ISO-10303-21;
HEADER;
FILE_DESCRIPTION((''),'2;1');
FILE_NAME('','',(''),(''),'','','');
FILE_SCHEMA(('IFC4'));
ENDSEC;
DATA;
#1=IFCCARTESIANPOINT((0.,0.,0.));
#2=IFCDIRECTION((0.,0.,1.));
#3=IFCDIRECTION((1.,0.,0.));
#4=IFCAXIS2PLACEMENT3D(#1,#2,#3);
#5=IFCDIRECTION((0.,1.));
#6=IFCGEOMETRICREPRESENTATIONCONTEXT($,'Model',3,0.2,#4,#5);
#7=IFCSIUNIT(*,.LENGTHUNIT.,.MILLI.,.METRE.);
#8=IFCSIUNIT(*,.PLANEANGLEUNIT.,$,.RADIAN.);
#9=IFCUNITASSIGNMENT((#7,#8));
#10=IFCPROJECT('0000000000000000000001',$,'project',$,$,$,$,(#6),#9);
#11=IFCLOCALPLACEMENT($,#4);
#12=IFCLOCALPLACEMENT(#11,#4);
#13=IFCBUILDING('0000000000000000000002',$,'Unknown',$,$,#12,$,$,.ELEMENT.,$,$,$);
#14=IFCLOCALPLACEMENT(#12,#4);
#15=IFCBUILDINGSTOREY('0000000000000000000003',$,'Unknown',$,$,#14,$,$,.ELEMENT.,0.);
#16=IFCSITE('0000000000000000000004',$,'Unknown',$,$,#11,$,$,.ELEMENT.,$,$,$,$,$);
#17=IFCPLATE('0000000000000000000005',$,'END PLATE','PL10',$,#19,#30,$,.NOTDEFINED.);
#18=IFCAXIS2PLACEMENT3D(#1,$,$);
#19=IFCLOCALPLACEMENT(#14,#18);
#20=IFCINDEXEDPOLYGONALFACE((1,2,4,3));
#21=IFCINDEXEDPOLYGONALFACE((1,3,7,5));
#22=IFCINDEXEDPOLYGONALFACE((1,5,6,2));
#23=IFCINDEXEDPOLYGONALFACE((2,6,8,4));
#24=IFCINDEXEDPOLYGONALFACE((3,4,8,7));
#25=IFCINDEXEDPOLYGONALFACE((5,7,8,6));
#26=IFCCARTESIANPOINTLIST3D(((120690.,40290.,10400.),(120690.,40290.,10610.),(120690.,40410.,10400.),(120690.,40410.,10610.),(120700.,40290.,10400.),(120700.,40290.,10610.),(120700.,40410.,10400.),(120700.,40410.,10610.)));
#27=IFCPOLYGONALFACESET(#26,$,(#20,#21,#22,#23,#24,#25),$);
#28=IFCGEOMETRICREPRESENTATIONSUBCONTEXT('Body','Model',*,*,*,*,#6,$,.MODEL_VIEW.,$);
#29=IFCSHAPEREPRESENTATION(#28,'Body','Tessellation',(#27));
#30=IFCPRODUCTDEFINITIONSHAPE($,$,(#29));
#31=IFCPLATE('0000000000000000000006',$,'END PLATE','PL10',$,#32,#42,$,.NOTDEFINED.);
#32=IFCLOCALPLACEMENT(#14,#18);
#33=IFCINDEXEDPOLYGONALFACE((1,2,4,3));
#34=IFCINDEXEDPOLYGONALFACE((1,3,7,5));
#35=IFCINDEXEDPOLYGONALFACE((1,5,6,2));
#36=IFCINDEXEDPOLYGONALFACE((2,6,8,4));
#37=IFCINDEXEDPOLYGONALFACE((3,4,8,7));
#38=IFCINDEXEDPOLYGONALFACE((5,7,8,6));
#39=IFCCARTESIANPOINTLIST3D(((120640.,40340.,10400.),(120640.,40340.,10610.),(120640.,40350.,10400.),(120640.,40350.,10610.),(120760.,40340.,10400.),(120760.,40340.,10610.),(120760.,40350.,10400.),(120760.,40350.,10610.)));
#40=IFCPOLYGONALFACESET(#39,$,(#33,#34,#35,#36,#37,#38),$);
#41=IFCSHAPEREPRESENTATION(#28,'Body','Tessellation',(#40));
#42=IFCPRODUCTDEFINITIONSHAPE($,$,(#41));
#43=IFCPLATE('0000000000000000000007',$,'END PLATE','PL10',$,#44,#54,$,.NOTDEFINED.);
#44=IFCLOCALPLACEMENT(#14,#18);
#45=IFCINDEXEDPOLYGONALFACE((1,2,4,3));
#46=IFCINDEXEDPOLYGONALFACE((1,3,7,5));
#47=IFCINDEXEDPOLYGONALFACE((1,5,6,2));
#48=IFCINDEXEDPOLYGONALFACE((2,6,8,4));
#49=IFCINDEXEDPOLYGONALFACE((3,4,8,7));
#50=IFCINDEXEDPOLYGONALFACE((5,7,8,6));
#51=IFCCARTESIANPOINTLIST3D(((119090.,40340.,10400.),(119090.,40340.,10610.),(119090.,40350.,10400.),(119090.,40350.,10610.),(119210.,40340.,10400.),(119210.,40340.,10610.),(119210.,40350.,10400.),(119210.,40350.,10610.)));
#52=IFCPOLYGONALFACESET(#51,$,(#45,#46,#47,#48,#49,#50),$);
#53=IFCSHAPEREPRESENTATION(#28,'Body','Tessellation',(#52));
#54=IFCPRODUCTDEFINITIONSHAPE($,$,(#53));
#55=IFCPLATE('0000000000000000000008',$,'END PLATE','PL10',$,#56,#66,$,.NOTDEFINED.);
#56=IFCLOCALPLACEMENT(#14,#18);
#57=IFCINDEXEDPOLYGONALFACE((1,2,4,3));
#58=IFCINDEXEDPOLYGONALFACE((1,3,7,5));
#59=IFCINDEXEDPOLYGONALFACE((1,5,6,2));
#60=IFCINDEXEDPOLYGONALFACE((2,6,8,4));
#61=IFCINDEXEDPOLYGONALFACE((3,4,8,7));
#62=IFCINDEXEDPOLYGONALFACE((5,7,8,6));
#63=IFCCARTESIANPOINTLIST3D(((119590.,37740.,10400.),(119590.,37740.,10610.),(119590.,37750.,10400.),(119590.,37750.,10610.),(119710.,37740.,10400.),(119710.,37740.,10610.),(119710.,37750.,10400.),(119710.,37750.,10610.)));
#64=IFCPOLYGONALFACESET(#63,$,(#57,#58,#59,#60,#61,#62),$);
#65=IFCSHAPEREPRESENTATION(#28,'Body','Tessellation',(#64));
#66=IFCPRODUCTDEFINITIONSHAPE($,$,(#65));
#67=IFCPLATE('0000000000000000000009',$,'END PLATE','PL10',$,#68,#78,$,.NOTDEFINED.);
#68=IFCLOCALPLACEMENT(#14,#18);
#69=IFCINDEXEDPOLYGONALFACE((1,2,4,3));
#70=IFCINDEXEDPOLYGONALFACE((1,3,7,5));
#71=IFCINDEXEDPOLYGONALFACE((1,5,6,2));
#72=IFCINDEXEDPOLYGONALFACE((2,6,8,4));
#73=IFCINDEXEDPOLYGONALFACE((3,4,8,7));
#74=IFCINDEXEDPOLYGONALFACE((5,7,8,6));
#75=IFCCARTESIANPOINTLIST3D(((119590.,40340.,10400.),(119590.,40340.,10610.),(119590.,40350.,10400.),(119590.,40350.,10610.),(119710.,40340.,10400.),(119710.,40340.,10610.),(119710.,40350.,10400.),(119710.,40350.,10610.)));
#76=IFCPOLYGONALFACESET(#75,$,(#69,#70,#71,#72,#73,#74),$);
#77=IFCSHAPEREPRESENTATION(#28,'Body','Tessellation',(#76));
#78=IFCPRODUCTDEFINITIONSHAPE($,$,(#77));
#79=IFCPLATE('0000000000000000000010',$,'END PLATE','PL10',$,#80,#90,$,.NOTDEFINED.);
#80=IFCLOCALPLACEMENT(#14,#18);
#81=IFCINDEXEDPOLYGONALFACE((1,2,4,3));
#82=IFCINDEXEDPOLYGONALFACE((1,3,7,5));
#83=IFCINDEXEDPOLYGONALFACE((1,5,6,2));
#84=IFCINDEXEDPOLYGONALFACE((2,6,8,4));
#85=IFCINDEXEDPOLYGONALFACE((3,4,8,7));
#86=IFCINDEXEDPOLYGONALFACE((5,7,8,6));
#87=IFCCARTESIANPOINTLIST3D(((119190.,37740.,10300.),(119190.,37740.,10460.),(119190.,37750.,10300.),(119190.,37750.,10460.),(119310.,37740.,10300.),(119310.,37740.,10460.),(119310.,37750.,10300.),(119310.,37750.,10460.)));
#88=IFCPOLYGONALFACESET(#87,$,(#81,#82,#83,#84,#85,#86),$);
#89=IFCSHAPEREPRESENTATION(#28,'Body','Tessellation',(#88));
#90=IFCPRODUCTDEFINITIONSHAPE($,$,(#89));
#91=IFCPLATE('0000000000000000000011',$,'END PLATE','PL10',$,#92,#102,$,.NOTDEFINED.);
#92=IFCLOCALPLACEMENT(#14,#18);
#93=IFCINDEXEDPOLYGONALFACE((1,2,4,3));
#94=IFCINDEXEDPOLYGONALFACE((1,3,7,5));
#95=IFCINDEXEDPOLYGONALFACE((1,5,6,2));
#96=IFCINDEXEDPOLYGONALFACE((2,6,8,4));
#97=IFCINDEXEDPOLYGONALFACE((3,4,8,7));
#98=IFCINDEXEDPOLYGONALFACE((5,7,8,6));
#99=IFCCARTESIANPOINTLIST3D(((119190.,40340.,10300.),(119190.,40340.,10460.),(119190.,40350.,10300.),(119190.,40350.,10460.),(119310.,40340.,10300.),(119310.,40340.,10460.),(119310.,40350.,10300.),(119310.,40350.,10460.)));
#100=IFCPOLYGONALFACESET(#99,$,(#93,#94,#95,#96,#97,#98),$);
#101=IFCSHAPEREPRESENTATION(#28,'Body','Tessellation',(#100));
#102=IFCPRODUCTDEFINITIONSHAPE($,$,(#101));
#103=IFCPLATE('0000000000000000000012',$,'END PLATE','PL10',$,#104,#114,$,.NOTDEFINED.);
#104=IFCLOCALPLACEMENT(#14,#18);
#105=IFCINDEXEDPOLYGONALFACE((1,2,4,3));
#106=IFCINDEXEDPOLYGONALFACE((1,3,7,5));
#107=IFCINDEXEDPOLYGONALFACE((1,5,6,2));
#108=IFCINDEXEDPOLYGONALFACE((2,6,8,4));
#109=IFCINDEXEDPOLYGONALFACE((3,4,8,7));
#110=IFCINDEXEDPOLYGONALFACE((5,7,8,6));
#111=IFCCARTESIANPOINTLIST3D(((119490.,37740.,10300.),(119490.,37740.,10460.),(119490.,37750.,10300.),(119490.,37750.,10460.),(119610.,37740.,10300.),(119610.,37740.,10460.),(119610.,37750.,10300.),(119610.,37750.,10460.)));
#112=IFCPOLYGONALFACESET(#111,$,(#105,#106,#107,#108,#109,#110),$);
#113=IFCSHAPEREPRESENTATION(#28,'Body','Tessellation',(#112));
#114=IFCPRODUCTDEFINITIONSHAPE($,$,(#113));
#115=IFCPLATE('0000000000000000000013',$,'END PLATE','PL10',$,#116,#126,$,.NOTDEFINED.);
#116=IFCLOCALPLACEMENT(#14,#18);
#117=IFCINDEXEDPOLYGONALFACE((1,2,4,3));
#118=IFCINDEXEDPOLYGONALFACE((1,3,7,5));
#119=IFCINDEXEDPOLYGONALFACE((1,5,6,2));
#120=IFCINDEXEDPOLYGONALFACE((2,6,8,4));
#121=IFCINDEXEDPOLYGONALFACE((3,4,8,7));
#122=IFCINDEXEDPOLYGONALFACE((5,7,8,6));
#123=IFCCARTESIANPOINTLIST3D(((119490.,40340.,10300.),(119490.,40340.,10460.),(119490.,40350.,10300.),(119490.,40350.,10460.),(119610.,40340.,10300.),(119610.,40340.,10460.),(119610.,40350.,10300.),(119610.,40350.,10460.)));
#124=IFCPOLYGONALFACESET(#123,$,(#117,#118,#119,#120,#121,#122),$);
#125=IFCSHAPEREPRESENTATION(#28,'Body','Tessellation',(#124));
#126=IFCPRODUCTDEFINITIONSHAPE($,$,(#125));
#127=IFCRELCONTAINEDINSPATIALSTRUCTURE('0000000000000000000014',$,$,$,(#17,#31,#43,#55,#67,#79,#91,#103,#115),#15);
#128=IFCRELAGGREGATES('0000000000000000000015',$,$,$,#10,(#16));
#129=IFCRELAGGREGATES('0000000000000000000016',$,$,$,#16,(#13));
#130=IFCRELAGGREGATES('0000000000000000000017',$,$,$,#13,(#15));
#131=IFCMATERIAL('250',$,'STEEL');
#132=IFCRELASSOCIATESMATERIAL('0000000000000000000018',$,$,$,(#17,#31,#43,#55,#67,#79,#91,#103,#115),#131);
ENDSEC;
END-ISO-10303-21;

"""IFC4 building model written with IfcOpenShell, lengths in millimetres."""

from ifc_helpers import new_model, si_unit, direction, frame, origin_with_axes, place, context, subcontext, project, spatial, line, indexed_curve, outline, extrude, material, element, save


model = new_model("IFC4")

# Units and contexts
model_context = context("Model", 3, precision=0.2, world=origin_with_axes(), true_north=direction((0.0, 1.0)))
body_context = subcontext(model_context, "Body", "Model", "MODEL_VIEW")
ifc_project = project(units=[si_unit("LENGTHUNIT", "METRE", prefix="MILLI"), si_unit("PLANEANGLEUNIT", "RADIAN")], contexts=[model_context])

# Site, building, storey
site_placement = place(None, origin_with_axes())
site = spatial("IfcSite", under=ifc_project, at=site_placement, Name="Unknown", CompositionType="ELEMENT")
building_placement = place(site_placement, origin_with_axes())
building = spatial("IfcBuilding", under=site, at=building_placement, Name="Unknown", CompositionType="ELEMENT")
storey_placement = place(building_placement, origin_with_axes())
storey = spatial("IfcBuildingStorey", under=building, at=storey_placement, Name="Unknown", CompositionType="ELEMENT", Elevation=0.0)

# Plates
ifc_material_1 = material(Name="250", Category="STEEL")
for number, where, z_axis, x_axis, name in (
    (1, (120695.0, 40410.0, 10400.0), (-1.0, 0.0, 0.0), (0.0, -1.0, 0.0), "END PLATE"),
    (2, (120640.0, 40345.0, 10400.0), (0.0, -1.0, 0.0), (1.0, 0.0, 0.0), "END PLATE"),
    (3, (119090.0, 40345.0, 10400.0), (0.0, -1.0, 0.0), (1.0, 0.0, 0.0), "END PLATE"),
    (4, (119590.0, 37745.0, 10400.0), (0.0, -1.0, 0.0), (1.0, 0.0, 0.0), "END PLATE"),
    (5, (119590.0, 40345.0, 10400.0), (0.0, -1.0, 0.0), (1.0, 0.0, 0.0), "END PLATE"),
):
    element("IfcPlate", number, at=place(storey_placement, frame(where, z_axis=z_axis, x_axis=x_axis)), inside=storey, material=ifc_material_1, Name=name, Description="PL10", PredefinedType="NOTDEFINED", context=body_context, shape_type="SolidModel", body=[
        extrude(outline(indexed_curve([(0.0, 0.0), (120.0, 0.0), (120.0, 210.0), (0.0, 210.0)], segments=[line(1, 2, 3, 4, 1)])), frame((0.0, 0.0, 5.0), z_axis=(0.0, 0.0, 1.0), x_axis=(1.0, 0.0, 0.0)), (0.0, 0.0, -1.0), 10.0),
    ])
for number, where, z_axis, x_axis, name in (
    (6, (119190.0, 37745.0, 10300.0), (0.0, -1.0, 0.0), (1.0, 0.0, 0.0), "END PLATE"),
    (7, (119190.0, 40345.0, 10300.0), (0.0, -1.0, 0.0), (1.0, 0.0, 0.0), "END PLATE"),
    (8, (119490.0, 37745.0, 10300.0), (0.0, -1.0, 0.0), (1.0, 0.0, 0.0), "END PLATE"),
    (9, (119490.0, 40345.0, 10300.0), (0.0, -1.0, 0.0), (1.0, 0.0, 0.0), "END PLATE"),
):
    element("IfcPlate", number, at=place(storey_placement, frame(where, z_axis=z_axis, x_axis=x_axis)), inside=storey, material=ifc_material_1, Name=name, Description="PL10", PredefinedType="NOTDEFINED", context=body_context, shape_type="SolidModel", body=[
        extrude(outline(indexed_curve([(0.0, 0.0), (120.0, 0.0), (120.0, 160.0), (0.0, 160.0)], segments=[line(1, 2, 3, 4, 1)])), frame((0.0, 0.0, 5.0), z_axis=(0.0, 0.0, 1.0), x_axis=(1.0, 0.0, 0.0)), (0.0, 0.0, -1.0), 10.0),
    ])

save(model, "model.ifc")
